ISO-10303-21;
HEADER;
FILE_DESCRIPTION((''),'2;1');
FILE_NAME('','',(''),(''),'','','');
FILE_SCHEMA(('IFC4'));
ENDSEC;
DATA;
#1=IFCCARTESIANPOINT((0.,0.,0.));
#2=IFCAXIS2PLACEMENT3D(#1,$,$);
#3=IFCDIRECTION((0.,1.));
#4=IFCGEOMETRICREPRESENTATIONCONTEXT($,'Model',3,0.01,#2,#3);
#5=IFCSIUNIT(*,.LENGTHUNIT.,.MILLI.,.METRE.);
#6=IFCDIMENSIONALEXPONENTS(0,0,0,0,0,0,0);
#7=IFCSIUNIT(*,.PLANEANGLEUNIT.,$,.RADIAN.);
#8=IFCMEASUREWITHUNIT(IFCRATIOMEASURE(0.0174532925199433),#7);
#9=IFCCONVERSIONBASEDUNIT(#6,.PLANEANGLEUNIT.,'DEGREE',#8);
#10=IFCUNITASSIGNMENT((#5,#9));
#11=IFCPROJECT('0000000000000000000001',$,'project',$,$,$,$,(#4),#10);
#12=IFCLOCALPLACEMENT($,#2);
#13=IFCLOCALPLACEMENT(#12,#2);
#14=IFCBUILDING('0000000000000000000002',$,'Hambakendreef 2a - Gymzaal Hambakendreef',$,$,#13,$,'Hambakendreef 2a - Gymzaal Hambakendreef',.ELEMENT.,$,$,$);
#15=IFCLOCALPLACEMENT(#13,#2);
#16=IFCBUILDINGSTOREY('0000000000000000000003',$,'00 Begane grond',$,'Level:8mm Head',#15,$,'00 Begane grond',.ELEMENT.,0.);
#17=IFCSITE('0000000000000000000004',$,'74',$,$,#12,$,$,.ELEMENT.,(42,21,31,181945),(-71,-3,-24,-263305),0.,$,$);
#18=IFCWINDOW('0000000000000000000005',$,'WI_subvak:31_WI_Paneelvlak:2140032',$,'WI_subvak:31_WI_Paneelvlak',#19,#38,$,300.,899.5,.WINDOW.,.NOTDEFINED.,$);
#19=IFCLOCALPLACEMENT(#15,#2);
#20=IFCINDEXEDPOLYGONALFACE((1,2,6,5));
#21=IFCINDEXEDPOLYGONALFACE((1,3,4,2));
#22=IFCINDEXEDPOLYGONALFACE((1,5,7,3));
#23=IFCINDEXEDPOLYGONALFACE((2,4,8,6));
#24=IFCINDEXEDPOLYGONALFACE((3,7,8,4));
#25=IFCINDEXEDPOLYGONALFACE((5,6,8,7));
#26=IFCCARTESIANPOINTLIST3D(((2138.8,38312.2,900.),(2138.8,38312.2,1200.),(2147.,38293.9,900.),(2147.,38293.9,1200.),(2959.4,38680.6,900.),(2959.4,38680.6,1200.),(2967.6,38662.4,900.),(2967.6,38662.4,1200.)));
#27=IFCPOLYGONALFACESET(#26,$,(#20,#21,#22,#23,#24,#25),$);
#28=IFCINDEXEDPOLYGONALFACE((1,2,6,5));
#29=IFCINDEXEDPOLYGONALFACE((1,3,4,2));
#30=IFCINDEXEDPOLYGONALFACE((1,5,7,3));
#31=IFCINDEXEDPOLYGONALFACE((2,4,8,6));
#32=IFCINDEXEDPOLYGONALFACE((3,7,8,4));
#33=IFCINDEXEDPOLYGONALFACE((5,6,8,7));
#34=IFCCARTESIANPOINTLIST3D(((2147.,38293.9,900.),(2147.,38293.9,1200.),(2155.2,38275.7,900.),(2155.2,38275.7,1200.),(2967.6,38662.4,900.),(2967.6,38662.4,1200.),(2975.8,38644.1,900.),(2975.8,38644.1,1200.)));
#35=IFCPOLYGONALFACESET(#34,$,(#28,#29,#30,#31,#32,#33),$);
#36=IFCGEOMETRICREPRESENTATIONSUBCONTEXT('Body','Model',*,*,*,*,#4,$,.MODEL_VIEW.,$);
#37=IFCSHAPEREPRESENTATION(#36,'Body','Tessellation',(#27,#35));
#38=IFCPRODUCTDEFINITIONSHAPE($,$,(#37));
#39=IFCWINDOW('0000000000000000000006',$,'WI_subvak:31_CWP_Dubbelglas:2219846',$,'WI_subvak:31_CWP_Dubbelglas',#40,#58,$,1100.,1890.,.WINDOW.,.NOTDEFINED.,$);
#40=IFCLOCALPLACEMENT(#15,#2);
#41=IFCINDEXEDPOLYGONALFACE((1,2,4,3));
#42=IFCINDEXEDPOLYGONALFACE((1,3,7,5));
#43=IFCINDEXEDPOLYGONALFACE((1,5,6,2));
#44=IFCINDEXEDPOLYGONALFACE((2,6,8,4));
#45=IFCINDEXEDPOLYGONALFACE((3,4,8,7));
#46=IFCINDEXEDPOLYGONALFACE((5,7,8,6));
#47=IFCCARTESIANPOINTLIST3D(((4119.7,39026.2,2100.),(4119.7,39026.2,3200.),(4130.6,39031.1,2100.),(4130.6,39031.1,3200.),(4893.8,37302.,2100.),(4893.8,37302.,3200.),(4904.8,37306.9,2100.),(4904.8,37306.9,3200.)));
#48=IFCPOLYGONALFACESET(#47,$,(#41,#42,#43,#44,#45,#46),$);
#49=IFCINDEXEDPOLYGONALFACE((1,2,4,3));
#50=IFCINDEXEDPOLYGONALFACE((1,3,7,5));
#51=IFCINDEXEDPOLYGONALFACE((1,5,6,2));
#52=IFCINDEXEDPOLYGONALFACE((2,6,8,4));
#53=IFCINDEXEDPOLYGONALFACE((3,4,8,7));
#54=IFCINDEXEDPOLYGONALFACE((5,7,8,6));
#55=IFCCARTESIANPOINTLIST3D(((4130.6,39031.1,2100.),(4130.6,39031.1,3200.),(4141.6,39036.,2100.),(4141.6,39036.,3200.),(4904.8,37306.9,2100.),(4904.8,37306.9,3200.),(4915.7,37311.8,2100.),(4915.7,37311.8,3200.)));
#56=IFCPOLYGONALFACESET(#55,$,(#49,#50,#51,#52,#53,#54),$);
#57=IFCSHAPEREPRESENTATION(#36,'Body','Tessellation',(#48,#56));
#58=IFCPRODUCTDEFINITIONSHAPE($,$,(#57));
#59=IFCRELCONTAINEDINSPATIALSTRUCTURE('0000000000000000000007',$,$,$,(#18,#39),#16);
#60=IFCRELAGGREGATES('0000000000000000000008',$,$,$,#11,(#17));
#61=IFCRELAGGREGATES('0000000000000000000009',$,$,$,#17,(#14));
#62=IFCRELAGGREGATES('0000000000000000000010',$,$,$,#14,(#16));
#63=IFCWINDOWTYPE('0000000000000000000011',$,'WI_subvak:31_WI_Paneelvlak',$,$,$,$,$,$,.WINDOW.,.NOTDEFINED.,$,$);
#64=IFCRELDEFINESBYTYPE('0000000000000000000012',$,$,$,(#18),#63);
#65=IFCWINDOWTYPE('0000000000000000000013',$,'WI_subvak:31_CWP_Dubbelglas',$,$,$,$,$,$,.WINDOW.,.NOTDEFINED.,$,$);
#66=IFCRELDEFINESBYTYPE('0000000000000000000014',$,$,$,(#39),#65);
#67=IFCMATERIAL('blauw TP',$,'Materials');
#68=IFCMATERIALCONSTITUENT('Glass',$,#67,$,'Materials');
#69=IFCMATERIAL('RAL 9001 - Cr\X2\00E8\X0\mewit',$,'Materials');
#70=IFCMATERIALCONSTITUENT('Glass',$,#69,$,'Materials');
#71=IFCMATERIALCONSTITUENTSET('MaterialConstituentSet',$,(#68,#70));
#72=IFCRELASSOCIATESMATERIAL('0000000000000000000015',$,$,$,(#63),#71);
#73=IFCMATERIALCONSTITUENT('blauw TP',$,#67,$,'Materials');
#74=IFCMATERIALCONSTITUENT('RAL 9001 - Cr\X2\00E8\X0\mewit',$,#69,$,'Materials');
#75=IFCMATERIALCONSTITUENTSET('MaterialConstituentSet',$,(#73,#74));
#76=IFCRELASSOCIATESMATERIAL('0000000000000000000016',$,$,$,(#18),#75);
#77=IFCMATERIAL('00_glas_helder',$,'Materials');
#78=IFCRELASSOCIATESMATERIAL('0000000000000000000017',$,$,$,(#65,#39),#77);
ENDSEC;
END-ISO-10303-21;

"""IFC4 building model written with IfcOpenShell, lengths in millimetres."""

from ifc_helpers import new_model, entity, si_unit, converted_unit, direction, frame, origin, place, context, subcontext, project, spatial, indexed_curve, outline, extrude, source, transform, mapped, material, constituent, constituent_set, type_object, type_shapes, element, save


model = new_model("IFC4")

# Units and contexts
model_context = context("Model", 3, precision=0.01, world=origin(), true_north=direction((0.0, 1.0)))
body_context = subcontext(model_context, "Body", "Model", "MODEL_VIEW")
ifc_project = project(units=[si_unit("LENGTHUNIT", "METRE", prefix="MILLI"), converted_unit("PLANEANGLEUNIT", "DEGREE", entity("IfcRatioMeasure", 0.0174532925199433), si_unit("PLANEANGLEUNIT", "RADIAN"), dimensions=[0, 0, 0, 0, 0, 0, 0])], contexts=[model_context])

# Site, building, storey
site_placement = place(None, origin())
site = spatial("IfcSite", under=ifc_project, at=site_placement, Name="74", CompositionType="ELEMENT", RefLatitude=(42, 21, 31, 181945), RefLongitude=(-71, -3, -24, -263305), RefElevation=0.0)
building_placement = place(site_placement, origin())
building = spatial("IfcBuilding", under=site, at=building_placement, Name="Hambakendreef 2a - Gymzaal Hambakendreef", LongName="Hambakendreef 2a - Gymzaal Hambakendreef", CompositionType="ELEMENT")
storey_placement = place(building_placement, origin())
storey = spatial("IfcBuildingStorey", under=building, at=storey_placement, Name="00 Begane grond", ObjectType="Level:8mm Head", LongName="00 Begane grond", CompositionType="ELEMENT", Elevation=0.0)

# Windows
ifc_material_1 = material(Name="00_glas_helder", Category="Materials")
ifc_material_2 = material(Name="blauw TP", Category="Materials")
ifc_constituent_1 = constituent(ifc_material_2, Name="blauw TP", Category="Materials")
ifc_material_3 = material(Name="RAL 9001 - Crèmewit", Category="Materials")
ifc_constituent_2 = constituent(ifc_material_3, Name="RAL 9001 - Crèmewit", Category="Materials")
ifc_constituent_set_1 = constituent_set(constituents=[ifc_constituent_1, ifc_constituent_2], Name="MaterialConstituentSet")
ifc_constituent_3 = constituent(ifc_material_2, Name="Glass", Category="Materials")
ifc_constituent_4 = constituent(ifc_material_3, Name="Glass", Category="Materials")
ifc_constituent_set_2 = constituent_set(constituents=[ifc_constituent_3, ifc_constituent_4], Name="MaterialConstituentSet")
window_type_1 = type_object("IfcWindowType", Name="WI_subvak:31_WI_Paneelvlak", PartitioningType="NOTDEFINED", PredefinedType="WINDOW", material=ifc_constituent_set_2)
shared_shape_1 = source(origin(), body_context, "Body", "SweptSolid", [
    extrude(outline(indexed_curve([(-10.0, -449.7), (10.0, -449.7), (10.0, 449.7), (-10.0, 449.7), (-10.0, -449.7)], self_intersect=False)), frame((0.0, 10.0, 0.0), z_axis=(0.0, 0.0, 1.0), x_axis=(0.0, -1.0, 0.0)), (0.0, 0.0, 1.0), 300.0),
    extrude(outline(indexed_curve([(-10.0, -449.7), (10.0, -449.7), (10.0, 449.7), (-10.0, 449.7), (-10.0, -449.7)], self_intersect=False)), frame((0.0, -10.0, 0.0), z_axis=(0.0, 0.0, 1.0), x_axis=(0.0, -1.0, 0.0)), (0.0, 0.0, 1.0), 300.0),
])
type_shapes(window_type_1, [shared_shape_1])
window_1_placement = place(storey_placement, frame((2557.3, 38478.2, 900.0), z_axis=(0.0, 0.0, 1.0), x_axis=(0.91227, 0.40959, 0.0)))
element("IfcWindow", 1, at=window_1_placement, inside=storey, type_object=window_type_1, material=ifc_constituent_set_1, Name="WI_subvak:31_WI_Paneelvlak:2140032", ObjectType="WI_subvak:31_WI_Paneelvlak", OverallHeight=300.0, OverallWidth=899.5, PartitioningType="NOTDEFINED", PredefinedType="WINDOW", context=body_context, shape_type="MappedRepresentation", body=[
    mapped(shared_shape_1, transform((0.0, 0.0, 0.0), scale=1.0)),
])
window_type_2 = type_object("IfcWindowType", Name="WI_subvak:31_CWP_Dubbelglas", PartitioningType="NOTDEFINED", PredefinedType="WINDOW", material=ifc_material_1)
shared_shape_2 = source(origin(), body_context, "Body", "SweptSolid", [
    extrude(outline(indexed_curve([(-6.0, -945.0), (6.0, -945.0), (6.0, 945.0), (-6.0, 945.0), (-6.0, -945.0)], self_intersect=False)), frame((0.0, 6.0, 0.0), z_axis=(0.0, 0.0, 1.0), x_axis=(0.0, -1.0, 0.0)), (0.0, 0.0, 1.0), 1100.0),
    extrude(outline(indexed_curve([(-6.0, -945.0), (6.0, -945.0), (6.0, 945.0), (-6.0, 945.0), (-6.0, -945.0)], self_intersect=False)), frame((0.0, -6.0, 0.0), z_axis=(0.0, 0.0, 1.0), x_axis=(0.0, -1.0, 0.0)), (0.0, 0.0, 1.0), 1100.0),
])
type_shapes(window_type_2, [shared_shape_2])
window_2_placement = place(storey_placement, frame((4517.7, 38169.0, 2100.0), z_axis=(0.0, 0.0, 1.0), x_axis=(-0.40959, 0.91227, 0.0)))
element("IfcWindow", 2, at=window_2_placement, inside=storey, type_object=window_type_2, material=ifc_material_1, Name="WI_subvak:31_CWP_Dubbelglas:2219846", ObjectType="WI_subvak:31_CWP_Dubbelglas", OverallHeight=1100.0, OverallWidth=1890.0, PartitioningType="NOTDEFINED", PredefinedType="WINDOW", context=body_context, shape_type="MappedRepresentation", body=[
    mapped(shared_shape_2, transform((0.0, 0.0, 0.0), scale=1.0)),
])

save(model, "model.ifc")
